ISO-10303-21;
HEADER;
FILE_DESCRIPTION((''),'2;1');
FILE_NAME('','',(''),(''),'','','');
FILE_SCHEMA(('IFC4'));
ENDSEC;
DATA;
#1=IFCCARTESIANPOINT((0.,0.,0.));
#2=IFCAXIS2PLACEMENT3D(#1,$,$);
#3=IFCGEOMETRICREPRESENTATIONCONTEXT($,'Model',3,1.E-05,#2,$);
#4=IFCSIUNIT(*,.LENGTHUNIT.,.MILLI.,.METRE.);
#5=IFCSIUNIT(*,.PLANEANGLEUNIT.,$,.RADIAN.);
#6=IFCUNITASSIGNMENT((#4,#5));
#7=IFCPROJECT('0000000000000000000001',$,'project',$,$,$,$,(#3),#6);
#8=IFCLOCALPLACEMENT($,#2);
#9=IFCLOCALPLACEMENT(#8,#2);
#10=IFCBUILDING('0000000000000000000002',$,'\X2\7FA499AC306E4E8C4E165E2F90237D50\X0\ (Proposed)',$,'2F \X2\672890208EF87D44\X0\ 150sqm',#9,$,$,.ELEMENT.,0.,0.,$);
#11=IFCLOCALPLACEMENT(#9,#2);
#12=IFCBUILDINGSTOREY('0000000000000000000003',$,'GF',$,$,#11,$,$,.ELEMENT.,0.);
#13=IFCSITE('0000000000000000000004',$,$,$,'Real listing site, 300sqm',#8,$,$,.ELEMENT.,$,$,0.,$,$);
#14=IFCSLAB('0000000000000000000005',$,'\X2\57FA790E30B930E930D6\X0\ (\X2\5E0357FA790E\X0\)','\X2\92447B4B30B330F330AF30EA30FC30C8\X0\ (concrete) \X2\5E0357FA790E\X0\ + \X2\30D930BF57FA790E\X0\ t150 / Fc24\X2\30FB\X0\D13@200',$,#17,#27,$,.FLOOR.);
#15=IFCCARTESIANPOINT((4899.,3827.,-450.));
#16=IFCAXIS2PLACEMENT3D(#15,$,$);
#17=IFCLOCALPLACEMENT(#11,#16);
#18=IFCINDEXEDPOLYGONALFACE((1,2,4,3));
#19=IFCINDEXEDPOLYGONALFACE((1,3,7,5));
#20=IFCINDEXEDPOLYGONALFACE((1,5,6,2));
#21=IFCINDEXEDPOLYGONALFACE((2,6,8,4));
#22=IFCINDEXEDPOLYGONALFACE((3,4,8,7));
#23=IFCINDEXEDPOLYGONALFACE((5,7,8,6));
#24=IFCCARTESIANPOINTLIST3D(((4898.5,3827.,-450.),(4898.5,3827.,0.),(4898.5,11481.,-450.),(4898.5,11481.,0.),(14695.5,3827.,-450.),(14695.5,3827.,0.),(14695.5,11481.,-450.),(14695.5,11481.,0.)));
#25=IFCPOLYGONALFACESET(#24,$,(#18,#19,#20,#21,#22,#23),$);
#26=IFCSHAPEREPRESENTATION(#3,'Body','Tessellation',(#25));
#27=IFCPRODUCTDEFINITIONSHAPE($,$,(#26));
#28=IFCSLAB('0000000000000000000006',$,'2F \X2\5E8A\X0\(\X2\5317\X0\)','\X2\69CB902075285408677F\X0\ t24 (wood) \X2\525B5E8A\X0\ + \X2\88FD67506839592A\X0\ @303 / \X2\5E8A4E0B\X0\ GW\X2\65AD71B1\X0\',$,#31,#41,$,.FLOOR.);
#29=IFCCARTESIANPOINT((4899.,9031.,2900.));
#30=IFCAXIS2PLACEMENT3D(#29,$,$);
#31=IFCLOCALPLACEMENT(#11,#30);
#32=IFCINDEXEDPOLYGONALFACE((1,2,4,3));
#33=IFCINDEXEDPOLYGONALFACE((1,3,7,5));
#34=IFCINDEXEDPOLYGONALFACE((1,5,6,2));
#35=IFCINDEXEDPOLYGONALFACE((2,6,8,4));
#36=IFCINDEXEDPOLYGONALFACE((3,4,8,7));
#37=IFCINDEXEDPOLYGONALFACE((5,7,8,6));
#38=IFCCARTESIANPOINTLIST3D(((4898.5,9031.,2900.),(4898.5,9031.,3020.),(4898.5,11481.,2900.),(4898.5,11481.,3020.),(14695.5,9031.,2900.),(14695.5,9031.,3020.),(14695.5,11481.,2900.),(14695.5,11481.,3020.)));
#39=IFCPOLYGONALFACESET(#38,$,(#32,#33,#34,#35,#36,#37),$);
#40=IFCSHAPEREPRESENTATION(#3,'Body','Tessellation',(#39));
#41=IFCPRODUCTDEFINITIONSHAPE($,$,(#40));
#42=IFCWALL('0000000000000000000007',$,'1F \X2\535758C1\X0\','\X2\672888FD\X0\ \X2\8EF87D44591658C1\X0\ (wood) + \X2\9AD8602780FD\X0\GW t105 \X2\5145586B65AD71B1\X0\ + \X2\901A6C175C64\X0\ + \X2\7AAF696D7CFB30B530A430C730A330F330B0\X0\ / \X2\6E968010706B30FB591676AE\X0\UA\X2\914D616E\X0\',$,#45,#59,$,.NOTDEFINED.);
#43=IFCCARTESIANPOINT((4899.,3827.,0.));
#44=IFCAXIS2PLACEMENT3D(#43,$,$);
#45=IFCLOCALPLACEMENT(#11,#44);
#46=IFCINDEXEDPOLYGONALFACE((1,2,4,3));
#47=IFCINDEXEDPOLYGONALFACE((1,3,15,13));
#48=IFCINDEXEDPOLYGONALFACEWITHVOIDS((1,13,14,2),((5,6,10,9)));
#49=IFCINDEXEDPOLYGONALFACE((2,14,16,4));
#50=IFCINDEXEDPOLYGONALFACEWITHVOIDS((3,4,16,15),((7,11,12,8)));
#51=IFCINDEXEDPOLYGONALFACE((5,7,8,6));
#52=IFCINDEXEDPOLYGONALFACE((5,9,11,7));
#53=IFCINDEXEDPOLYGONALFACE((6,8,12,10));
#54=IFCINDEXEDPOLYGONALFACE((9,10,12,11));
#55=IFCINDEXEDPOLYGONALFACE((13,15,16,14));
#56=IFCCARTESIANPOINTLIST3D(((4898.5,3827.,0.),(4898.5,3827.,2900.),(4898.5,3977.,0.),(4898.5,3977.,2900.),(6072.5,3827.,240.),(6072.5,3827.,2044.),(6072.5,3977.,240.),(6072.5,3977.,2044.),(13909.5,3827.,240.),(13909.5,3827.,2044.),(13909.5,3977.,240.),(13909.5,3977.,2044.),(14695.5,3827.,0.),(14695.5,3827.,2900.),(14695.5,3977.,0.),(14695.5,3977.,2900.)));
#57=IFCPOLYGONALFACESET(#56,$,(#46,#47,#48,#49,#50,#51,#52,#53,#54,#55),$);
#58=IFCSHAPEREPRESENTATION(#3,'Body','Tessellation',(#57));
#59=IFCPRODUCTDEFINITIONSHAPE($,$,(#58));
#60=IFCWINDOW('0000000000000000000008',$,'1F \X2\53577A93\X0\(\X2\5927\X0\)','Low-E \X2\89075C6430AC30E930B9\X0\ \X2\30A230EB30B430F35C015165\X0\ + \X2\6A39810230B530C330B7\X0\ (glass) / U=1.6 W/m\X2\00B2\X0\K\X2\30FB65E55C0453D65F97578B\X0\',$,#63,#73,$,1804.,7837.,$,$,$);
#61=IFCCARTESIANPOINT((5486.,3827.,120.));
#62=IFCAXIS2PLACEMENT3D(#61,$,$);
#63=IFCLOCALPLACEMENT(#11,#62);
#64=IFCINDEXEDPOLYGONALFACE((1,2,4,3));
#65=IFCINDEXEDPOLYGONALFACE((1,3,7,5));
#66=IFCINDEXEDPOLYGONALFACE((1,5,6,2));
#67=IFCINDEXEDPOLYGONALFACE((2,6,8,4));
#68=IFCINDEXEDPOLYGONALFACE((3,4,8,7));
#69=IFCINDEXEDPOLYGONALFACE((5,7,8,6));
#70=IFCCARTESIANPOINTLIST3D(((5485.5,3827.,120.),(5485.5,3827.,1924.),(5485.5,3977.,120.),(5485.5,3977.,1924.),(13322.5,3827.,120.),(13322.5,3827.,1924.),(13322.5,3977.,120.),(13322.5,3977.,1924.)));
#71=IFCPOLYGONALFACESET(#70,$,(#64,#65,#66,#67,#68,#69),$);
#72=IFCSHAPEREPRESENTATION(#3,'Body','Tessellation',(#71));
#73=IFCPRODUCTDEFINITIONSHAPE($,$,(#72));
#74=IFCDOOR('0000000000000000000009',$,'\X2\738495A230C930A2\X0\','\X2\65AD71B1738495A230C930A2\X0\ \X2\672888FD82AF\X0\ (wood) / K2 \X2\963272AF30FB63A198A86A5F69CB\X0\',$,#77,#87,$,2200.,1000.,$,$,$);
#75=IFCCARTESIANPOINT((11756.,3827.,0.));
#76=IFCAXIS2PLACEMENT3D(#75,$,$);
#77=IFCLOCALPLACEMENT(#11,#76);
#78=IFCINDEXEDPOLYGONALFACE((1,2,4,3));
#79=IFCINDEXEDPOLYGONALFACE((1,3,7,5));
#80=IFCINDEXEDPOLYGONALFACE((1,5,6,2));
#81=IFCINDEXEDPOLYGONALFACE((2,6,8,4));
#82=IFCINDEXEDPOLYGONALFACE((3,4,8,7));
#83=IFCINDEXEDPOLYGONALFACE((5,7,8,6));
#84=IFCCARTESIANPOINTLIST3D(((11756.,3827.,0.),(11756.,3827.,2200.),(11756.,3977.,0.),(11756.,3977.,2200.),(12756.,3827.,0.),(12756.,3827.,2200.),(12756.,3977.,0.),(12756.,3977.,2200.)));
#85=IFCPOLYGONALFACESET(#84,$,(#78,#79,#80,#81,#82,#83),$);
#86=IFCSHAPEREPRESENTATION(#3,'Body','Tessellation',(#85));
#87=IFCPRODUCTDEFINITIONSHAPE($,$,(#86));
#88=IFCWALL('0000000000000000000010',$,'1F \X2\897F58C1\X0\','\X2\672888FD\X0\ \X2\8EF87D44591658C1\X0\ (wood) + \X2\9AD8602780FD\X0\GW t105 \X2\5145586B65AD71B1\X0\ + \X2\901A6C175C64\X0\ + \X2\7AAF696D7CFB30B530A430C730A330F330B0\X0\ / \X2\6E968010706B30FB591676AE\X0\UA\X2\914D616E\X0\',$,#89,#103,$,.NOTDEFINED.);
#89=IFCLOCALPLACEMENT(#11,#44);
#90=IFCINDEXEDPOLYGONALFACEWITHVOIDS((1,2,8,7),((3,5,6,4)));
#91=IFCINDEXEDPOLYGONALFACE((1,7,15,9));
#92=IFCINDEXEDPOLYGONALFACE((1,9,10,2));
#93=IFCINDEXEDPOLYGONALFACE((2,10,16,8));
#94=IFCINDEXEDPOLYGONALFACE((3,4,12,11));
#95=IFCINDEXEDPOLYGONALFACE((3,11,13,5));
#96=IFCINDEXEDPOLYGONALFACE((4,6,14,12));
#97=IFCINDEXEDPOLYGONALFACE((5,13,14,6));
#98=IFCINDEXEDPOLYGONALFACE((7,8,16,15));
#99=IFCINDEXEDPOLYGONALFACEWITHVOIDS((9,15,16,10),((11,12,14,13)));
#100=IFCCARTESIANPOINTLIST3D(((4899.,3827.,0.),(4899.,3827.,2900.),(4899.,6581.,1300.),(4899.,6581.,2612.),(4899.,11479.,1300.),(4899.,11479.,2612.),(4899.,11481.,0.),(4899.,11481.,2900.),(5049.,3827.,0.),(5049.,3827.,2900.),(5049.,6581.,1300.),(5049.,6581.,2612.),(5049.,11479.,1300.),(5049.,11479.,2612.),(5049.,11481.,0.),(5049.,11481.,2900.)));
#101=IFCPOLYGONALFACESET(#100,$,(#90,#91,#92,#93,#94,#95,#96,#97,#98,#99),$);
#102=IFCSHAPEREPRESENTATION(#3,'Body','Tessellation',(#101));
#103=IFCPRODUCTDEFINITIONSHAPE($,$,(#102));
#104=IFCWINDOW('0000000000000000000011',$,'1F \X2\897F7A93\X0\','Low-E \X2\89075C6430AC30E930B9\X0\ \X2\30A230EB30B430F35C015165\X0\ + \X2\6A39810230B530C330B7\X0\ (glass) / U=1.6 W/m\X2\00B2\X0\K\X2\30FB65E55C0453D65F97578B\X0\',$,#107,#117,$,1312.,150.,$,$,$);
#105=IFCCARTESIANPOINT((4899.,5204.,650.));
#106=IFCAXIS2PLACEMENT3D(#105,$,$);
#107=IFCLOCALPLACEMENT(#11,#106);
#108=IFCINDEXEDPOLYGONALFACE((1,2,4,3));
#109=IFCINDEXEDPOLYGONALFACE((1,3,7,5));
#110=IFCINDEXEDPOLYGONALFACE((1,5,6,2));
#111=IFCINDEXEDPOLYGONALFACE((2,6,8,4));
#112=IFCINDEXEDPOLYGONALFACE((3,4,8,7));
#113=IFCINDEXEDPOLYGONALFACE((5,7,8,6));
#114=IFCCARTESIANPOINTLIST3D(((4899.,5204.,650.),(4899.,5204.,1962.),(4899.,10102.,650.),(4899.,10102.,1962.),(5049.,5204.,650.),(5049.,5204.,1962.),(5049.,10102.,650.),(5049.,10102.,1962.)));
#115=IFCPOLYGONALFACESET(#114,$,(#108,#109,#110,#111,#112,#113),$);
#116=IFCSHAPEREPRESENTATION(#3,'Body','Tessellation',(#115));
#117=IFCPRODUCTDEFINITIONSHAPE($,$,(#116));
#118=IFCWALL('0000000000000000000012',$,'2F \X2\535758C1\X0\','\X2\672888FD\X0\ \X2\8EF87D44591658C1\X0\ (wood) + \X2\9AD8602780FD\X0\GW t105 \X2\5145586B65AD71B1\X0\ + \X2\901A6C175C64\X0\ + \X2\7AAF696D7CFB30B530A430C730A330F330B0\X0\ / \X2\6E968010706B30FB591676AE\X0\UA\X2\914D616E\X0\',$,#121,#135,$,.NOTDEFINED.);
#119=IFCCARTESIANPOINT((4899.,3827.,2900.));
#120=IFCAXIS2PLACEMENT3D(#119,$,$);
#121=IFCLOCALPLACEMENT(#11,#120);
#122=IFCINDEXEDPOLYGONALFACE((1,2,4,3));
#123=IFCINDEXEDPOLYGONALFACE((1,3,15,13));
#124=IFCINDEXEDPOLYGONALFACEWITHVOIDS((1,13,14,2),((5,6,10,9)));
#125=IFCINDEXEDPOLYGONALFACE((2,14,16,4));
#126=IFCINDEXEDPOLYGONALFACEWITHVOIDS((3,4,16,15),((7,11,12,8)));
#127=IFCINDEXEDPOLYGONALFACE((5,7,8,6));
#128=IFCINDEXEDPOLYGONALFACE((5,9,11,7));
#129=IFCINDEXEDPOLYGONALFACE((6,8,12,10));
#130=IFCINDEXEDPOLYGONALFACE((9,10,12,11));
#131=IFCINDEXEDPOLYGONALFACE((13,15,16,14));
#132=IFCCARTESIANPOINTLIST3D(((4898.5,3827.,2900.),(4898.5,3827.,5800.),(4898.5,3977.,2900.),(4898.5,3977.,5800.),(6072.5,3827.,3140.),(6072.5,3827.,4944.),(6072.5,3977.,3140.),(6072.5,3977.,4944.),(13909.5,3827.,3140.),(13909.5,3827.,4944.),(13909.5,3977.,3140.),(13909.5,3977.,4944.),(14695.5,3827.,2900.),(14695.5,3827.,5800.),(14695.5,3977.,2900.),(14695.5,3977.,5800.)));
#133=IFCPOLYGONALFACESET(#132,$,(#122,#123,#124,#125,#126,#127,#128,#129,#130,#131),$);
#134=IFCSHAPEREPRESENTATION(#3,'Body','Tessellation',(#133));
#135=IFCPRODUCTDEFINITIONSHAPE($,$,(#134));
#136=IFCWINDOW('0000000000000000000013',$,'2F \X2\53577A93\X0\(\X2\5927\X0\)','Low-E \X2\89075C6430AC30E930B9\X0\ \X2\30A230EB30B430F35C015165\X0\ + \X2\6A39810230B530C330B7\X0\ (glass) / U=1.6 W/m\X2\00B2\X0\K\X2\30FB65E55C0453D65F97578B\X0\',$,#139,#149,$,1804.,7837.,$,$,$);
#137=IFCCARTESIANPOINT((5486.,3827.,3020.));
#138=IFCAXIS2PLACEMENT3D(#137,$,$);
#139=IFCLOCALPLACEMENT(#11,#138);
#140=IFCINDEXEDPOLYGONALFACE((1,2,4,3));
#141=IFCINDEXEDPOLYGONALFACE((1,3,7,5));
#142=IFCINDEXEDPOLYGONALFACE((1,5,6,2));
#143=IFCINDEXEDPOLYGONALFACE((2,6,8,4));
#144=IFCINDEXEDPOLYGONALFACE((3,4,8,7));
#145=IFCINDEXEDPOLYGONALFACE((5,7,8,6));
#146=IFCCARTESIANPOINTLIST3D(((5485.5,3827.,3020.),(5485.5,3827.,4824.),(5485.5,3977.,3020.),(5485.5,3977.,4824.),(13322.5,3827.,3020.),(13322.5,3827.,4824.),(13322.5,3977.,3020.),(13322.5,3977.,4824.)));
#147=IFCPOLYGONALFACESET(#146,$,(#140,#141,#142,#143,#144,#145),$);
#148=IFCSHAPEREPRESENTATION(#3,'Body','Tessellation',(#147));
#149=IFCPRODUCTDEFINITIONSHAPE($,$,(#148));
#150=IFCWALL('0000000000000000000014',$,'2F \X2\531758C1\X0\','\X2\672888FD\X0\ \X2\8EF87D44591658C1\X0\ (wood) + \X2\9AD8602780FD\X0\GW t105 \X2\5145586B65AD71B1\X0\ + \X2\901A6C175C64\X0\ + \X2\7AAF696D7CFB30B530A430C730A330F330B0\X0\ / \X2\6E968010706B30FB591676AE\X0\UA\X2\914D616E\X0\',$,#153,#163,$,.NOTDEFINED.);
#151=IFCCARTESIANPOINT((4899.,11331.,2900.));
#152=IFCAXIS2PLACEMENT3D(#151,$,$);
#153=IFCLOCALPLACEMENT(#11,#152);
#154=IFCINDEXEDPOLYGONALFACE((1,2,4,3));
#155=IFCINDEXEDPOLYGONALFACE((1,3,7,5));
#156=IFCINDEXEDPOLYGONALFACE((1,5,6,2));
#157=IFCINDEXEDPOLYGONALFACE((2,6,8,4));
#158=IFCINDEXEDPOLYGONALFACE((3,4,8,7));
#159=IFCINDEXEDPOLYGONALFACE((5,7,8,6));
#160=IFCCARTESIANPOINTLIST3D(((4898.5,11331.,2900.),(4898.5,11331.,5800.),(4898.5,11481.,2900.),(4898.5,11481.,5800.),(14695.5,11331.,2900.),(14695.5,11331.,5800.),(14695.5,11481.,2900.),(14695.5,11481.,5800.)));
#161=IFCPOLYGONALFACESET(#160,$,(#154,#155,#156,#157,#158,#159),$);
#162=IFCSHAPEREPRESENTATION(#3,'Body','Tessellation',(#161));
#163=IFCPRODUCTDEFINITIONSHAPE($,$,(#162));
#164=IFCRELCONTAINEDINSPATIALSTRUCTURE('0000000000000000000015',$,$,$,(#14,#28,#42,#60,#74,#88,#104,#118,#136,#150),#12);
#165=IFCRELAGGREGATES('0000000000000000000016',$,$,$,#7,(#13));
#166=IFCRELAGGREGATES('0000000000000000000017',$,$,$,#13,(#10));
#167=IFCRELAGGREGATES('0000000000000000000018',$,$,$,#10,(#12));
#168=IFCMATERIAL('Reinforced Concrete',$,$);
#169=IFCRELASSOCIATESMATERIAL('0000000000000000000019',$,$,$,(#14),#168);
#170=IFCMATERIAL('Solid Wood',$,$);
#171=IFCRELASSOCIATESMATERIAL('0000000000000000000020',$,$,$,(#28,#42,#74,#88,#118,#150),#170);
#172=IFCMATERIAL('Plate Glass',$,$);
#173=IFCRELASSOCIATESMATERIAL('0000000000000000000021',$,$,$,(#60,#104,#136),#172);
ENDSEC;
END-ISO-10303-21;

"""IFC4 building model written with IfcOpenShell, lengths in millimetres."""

from ifc_helpers import new_model, si_unit, frame, frame_2d, origin, place, context, project, spatial, rectangle, extrude, material, element, fill, save


model = new_model("IFC4")

# Units and contexts
model_context = context("Model", 3, precision=1e-05, world=origin())
ifc_project = project(units=[si_unit("LENGTHUNIT", "METRE", prefix="MILLI"), si_unit("PLANEANGLEUNIT", "RADIAN")], contexts=[model_context])

# Site, building, storey
site_placement = place(None, origin())
site = spatial("IfcSite", under=ifc_project, at=site_placement, ObjectType="Real listing site, 300sqm", CompositionType="ELEMENT", RefElevation=0.0)
building_placement = place(site_placement, origin())
building = spatial("IfcBuilding", under=site, at=building_placement, Name="群馬の二世帯連結 (Proposed)", ObjectType="2F 木造軸組 150sqm", CompositionType="ELEMENT", ElevationOfRefHeight=0.0, ElevationOfTerrain=0.0)
storey_placement = place(building_placement, origin())
storey = spatial("IfcBuildingStorey", under=building, at=storey_placement, Name="GF", CompositionType="ELEMENT", Elevation=0.0)

# Slabs
ifc_material_1 = material(Name="Reinforced Concrete")
slab_1_placement = place(storey_placement, frame((4899.0, 3827.0, -450.0)))
element("IfcSlab", 1, at=slab_1_placement, inside=storey, material=ifc_material_1, Name="基礎スラブ (布基礎)", Description="鉄筋コンクリート (concrete) 布基礎 + ベタ基礎 t150 / Fc24・D13@200", PredefinedType="FLOOR", context=model_context, shape_type="SweptSolid", body=[
    extrude(rectangle(XDim=9797.0, YDim=7654.0, at=frame_2d((4898.0, 3827.0))), frame((4899.0, 3827.0, -450.0)), (0.0, 0.0, 1.0), 450.0),
])
ifc_material_2 = material(Name="Solid Wood")
slab_2_placement = place(storey_placement, frame((4899.0, 9031.0, 2900.0)))
element("IfcSlab", 2, at=slab_2_placement, inside=storey, material=ifc_material_2, Name="2F 床(北)", Description="構造用合板 t24 (wood) 剛床 + 製材根太 @303 / 床下 GW断熱", PredefinedType="FLOOR", context=model_context, shape_type="SweptSolid", body=[
    extrude(rectangle(XDim=9797.0, YDim=2450.0, at=frame_2d((4898.0, 1225.0))), frame((4899.0, 9031.0, 2900.0)), (0.0, 0.0, 1.0), 120.0),
])

# Wall, openings, window, door
wall_1_placement = place(storey_placement, frame((4899.0, 3827.0, 0.0)))
wall_1 = element("IfcWall", 3, at=wall_1_placement, inside=storey, material=ifc_material_2, Name="1F 南壁", Description="木製 軸組外壁 (wood) + 高性能GW t105 充填断熱 + 通気層 + 窯業系サイディング / 準耐火・外皮UA配慮", PredefinedType="NOTDEFINED", context=model_context, shape_type="SweptSolid", body=[
    extrude(rectangle(XDim=9797.0, YDim=150.0, at=frame_2d((4898.0, 75.0))), frame((4899.0, 3827.0, 0.0)), (0.0, 0.0, 1.0), 2900.0),
])
opening_1_placement = place(storey_placement, frame((5486.0, 3827.0, 120.0)))
opening_1 = element("IfcOpeningElement", 4, at=opening_1_placement, cuts=wall_1, PredefinedType="NOTDEFINED", context=model_context, shape_type="SweptSolid", body=[
    extrude(rectangle(XDim=7837.0, YDim=150.0, at=frame_2d((3918.0, 75.0))), frame((5486.0, 3827.0, 120.0)), (0.0, 0.0, 1.0), 1804.0),
])
opening_2_placement = place(storey_placement, frame((11756.0, 3827.0, 0.0)))
opening_2 = element("IfcOpeningElement", 5, at=opening_2_placement, cuts=wall_1, PredefinedType="NOTDEFINED", context=model_context, shape_type="SweptSolid", body=[
    extrude(rectangle(XDim=1000.0, YDim=150.0, at=frame_2d((500.0, 75.0))), frame((11756.0, 3827.0, 0.0)), (0.0, 0.0, 1.0), 2200.0),
])
ifc_material_3 = material(Name="Plate Glass")
window_1_placement = place(storey_placement, frame((5486.0, 3827.0, 120.0)))
window_1 = element("IfcWindow", 6, at=window_1_placement, inside=storey, material=ifc_material_3, Name="1F 南窓(大)", Description="Low-E 複層ガラス アルゴン封入 + 樹脂サッシ (glass) / U=1.6 W/m²K・日射取得型", OverallHeight=1804.0, OverallWidth=7837.0, context=model_context, shape_type="SweptSolid", body=[
    extrude(rectangle(XDim=7837.0, YDim=150.0, at=frame_2d((3918.0, 75.0))), frame((5486.0, 3827.0, 120.0)), (0.0, 0.0, 1.0), 1804.0),
])
fill(opening_1, window_1)
door_placement = place(storey_placement, frame((11756.0, 3827.0, 0.0)))
door = element("IfcDoor", 7, at=door_placement, inside=storey, material=ifc_material_2, Name="玄関ドア", Description="断熱玄関ドア 木製芯 (wood) / K2 防犯・採風機構", OverallHeight=2200.0, OverallWidth=1000.0, context=model_context, shape_type="SweptSolid", body=[
    extrude(rectangle(XDim=1000.0, YDim=150.0, at=frame_2d((500.0, 75.0))), frame((11756.0, 3827.0, 0.0)), (0.0, 0.0, 1.0), 2200.0),
])
fill(opening_2, door)

# Walls, openings, windows
wall_2_placement = place(storey_placement, frame((4899.0, 3827.0, 0.0)))
wall_2 = element("IfcWall", 8, at=wall_2_placement, inside=storey, material=ifc_material_2, Name="1F 西壁", Description="木製 軸組外壁 (wood) + 高性能GW t105 充填断熱 + 通気層 + 窯業系サイディング / 準耐火・外皮UA配慮", PredefinedType="NOTDEFINED", context=model_context, shape_type="SweptSolid", body=[
    extrude(rectangle(XDim=150.0, YDim=7654.0, at=frame_2d((75.0, 3827.0))), frame((4899.0, 3827.0, 0.0)), (0.0, 0.0, 1.0), 2900.0),
])
opening_3_placement = place(storey_placement, frame((4899.0, 5204.0, 650.0)))
opening_3 = element("IfcOpeningElement", 9, at=opening_3_placement, cuts=wall_2, PredefinedType="NOTDEFINED", context=model_context, shape_type="SweptSolid", body=[
    extrude(rectangle(XDim=150.0, YDim=4898.0, at=frame_2d((75.0, 2449.0))), frame((4899.0, 5204.0, 650.0)), (0.0, 0.0, 1.0), 1312.0),
])
window_2_placement = place(storey_placement, frame((4899.0, 5204.0, 650.0)))
window_2 = element("IfcWindow", 10, at=window_2_placement, inside=storey, material=ifc_material_3, Name="1F 西窓", Description="Low-E 複層ガラス アルゴン封入 + 樹脂サッシ (glass) / U=1.6 W/m²K・日射取得型", OverallHeight=1312.0, OverallWidth=150.0, context=model_context, shape_type="SweptSolid", body=[
    extrude(rectangle(XDim=150.0, YDim=4898.0, at=frame_2d((75.0, 2449.0))), frame((4899.0, 5204.0, 650.0)), (0.0, 0.0, 1.0), 1312.0),
])
fill(opening_3, window_2)
wall_3_placement = place(storey_placement, frame((4899.0, 3827.0, 2900.0)))
wall_3 = element("IfcWall", 11, at=wall_3_placement, inside=storey, material=ifc_material_2, Name="2F 南壁", Description="木製 軸組外壁 (wood) + 高性能GW t105 充填断熱 + 通気層 + 窯業系サイディング / 準耐火・外皮UA配慮", PredefinedType="NOTDEFINED", context=model_context, shape_type="SweptSolid", body=[
    extrude(rectangle(XDim=9797.0, YDim=150.0, at=frame_2d((4898.0, 75.0))), frame((4899.0, 3827.0, 2900.0)), (0.0, 0.0, 1.0), 2900.0),
])
opening_4_placement = place(storey_placement, frame((5486.0, 3827.0, 3020.0)))
opening_4 = element("IfcOpeningElement", 12, at=opening_4_placement, cuts=wall_3, PredefinedType="NOTDEFINED", context=model_context, shape_type="SweptSolid", body=[
    extrude(rectangle(XDim=7837.0, YDim=150.0, at=frame_2d((3918.0, 75.0))), frame((5486.0, 3827.0, 3020.0)), (0.0, 0.0, 1.0), 1804.0),
])
window_3_placement = place(storey_placement, frame((5486.0, 3827.0, 3020.0)))
window_3 = element("IfcWindow", 13, at=window_3_placement, inside=storey, material=ifc_material_3, Name="2F 南窓(大)", Description="Low-E 複層ガラス アルゴン封入 + 樹脂サッシ (glass) / U=1.6 W/m²K・日射取得型", OverallHeight=1804.0, OverallWidth=7837.0, context=model_context, shape_type="SweptSolid", body=[
    extrude(rectangle(XDim=7837.0, YDim=150.0, at=frame_2d((3918.0, 75.0))), frame((5486.0, 3827.0, 3020.0)), (0.0, 0.0, 1.0), 1804.0),
])
fill(opening_4, window_3)

# Wall
wall_4_placement = place(storey_placement, frame((4899.0, 11331.0, 2900.0)))
element("IfcWall", 14, at=wall_4_placement, inside=storey, material=ifc_material_2, Name="2F 北壁", Description="木製 軸組外壁 (wood) + 高性能GW t105 充填断熱 + 通気層 + 窯業系サイディング / 準耐火・外皮UA配慮", PredefinedType="NOTDEFINED", context=model_context, shape_type="SweptSolid", body=[
    extrude(rectangle(XDim=9797.0, YDim=150.0, at=frame_2d((4898.0, 75.0))), frame((4899.0, 11331.0, 2900.0)), (0.0, 0.0, 1.0), 2900.0),
])

save(model, "model.ifc")
